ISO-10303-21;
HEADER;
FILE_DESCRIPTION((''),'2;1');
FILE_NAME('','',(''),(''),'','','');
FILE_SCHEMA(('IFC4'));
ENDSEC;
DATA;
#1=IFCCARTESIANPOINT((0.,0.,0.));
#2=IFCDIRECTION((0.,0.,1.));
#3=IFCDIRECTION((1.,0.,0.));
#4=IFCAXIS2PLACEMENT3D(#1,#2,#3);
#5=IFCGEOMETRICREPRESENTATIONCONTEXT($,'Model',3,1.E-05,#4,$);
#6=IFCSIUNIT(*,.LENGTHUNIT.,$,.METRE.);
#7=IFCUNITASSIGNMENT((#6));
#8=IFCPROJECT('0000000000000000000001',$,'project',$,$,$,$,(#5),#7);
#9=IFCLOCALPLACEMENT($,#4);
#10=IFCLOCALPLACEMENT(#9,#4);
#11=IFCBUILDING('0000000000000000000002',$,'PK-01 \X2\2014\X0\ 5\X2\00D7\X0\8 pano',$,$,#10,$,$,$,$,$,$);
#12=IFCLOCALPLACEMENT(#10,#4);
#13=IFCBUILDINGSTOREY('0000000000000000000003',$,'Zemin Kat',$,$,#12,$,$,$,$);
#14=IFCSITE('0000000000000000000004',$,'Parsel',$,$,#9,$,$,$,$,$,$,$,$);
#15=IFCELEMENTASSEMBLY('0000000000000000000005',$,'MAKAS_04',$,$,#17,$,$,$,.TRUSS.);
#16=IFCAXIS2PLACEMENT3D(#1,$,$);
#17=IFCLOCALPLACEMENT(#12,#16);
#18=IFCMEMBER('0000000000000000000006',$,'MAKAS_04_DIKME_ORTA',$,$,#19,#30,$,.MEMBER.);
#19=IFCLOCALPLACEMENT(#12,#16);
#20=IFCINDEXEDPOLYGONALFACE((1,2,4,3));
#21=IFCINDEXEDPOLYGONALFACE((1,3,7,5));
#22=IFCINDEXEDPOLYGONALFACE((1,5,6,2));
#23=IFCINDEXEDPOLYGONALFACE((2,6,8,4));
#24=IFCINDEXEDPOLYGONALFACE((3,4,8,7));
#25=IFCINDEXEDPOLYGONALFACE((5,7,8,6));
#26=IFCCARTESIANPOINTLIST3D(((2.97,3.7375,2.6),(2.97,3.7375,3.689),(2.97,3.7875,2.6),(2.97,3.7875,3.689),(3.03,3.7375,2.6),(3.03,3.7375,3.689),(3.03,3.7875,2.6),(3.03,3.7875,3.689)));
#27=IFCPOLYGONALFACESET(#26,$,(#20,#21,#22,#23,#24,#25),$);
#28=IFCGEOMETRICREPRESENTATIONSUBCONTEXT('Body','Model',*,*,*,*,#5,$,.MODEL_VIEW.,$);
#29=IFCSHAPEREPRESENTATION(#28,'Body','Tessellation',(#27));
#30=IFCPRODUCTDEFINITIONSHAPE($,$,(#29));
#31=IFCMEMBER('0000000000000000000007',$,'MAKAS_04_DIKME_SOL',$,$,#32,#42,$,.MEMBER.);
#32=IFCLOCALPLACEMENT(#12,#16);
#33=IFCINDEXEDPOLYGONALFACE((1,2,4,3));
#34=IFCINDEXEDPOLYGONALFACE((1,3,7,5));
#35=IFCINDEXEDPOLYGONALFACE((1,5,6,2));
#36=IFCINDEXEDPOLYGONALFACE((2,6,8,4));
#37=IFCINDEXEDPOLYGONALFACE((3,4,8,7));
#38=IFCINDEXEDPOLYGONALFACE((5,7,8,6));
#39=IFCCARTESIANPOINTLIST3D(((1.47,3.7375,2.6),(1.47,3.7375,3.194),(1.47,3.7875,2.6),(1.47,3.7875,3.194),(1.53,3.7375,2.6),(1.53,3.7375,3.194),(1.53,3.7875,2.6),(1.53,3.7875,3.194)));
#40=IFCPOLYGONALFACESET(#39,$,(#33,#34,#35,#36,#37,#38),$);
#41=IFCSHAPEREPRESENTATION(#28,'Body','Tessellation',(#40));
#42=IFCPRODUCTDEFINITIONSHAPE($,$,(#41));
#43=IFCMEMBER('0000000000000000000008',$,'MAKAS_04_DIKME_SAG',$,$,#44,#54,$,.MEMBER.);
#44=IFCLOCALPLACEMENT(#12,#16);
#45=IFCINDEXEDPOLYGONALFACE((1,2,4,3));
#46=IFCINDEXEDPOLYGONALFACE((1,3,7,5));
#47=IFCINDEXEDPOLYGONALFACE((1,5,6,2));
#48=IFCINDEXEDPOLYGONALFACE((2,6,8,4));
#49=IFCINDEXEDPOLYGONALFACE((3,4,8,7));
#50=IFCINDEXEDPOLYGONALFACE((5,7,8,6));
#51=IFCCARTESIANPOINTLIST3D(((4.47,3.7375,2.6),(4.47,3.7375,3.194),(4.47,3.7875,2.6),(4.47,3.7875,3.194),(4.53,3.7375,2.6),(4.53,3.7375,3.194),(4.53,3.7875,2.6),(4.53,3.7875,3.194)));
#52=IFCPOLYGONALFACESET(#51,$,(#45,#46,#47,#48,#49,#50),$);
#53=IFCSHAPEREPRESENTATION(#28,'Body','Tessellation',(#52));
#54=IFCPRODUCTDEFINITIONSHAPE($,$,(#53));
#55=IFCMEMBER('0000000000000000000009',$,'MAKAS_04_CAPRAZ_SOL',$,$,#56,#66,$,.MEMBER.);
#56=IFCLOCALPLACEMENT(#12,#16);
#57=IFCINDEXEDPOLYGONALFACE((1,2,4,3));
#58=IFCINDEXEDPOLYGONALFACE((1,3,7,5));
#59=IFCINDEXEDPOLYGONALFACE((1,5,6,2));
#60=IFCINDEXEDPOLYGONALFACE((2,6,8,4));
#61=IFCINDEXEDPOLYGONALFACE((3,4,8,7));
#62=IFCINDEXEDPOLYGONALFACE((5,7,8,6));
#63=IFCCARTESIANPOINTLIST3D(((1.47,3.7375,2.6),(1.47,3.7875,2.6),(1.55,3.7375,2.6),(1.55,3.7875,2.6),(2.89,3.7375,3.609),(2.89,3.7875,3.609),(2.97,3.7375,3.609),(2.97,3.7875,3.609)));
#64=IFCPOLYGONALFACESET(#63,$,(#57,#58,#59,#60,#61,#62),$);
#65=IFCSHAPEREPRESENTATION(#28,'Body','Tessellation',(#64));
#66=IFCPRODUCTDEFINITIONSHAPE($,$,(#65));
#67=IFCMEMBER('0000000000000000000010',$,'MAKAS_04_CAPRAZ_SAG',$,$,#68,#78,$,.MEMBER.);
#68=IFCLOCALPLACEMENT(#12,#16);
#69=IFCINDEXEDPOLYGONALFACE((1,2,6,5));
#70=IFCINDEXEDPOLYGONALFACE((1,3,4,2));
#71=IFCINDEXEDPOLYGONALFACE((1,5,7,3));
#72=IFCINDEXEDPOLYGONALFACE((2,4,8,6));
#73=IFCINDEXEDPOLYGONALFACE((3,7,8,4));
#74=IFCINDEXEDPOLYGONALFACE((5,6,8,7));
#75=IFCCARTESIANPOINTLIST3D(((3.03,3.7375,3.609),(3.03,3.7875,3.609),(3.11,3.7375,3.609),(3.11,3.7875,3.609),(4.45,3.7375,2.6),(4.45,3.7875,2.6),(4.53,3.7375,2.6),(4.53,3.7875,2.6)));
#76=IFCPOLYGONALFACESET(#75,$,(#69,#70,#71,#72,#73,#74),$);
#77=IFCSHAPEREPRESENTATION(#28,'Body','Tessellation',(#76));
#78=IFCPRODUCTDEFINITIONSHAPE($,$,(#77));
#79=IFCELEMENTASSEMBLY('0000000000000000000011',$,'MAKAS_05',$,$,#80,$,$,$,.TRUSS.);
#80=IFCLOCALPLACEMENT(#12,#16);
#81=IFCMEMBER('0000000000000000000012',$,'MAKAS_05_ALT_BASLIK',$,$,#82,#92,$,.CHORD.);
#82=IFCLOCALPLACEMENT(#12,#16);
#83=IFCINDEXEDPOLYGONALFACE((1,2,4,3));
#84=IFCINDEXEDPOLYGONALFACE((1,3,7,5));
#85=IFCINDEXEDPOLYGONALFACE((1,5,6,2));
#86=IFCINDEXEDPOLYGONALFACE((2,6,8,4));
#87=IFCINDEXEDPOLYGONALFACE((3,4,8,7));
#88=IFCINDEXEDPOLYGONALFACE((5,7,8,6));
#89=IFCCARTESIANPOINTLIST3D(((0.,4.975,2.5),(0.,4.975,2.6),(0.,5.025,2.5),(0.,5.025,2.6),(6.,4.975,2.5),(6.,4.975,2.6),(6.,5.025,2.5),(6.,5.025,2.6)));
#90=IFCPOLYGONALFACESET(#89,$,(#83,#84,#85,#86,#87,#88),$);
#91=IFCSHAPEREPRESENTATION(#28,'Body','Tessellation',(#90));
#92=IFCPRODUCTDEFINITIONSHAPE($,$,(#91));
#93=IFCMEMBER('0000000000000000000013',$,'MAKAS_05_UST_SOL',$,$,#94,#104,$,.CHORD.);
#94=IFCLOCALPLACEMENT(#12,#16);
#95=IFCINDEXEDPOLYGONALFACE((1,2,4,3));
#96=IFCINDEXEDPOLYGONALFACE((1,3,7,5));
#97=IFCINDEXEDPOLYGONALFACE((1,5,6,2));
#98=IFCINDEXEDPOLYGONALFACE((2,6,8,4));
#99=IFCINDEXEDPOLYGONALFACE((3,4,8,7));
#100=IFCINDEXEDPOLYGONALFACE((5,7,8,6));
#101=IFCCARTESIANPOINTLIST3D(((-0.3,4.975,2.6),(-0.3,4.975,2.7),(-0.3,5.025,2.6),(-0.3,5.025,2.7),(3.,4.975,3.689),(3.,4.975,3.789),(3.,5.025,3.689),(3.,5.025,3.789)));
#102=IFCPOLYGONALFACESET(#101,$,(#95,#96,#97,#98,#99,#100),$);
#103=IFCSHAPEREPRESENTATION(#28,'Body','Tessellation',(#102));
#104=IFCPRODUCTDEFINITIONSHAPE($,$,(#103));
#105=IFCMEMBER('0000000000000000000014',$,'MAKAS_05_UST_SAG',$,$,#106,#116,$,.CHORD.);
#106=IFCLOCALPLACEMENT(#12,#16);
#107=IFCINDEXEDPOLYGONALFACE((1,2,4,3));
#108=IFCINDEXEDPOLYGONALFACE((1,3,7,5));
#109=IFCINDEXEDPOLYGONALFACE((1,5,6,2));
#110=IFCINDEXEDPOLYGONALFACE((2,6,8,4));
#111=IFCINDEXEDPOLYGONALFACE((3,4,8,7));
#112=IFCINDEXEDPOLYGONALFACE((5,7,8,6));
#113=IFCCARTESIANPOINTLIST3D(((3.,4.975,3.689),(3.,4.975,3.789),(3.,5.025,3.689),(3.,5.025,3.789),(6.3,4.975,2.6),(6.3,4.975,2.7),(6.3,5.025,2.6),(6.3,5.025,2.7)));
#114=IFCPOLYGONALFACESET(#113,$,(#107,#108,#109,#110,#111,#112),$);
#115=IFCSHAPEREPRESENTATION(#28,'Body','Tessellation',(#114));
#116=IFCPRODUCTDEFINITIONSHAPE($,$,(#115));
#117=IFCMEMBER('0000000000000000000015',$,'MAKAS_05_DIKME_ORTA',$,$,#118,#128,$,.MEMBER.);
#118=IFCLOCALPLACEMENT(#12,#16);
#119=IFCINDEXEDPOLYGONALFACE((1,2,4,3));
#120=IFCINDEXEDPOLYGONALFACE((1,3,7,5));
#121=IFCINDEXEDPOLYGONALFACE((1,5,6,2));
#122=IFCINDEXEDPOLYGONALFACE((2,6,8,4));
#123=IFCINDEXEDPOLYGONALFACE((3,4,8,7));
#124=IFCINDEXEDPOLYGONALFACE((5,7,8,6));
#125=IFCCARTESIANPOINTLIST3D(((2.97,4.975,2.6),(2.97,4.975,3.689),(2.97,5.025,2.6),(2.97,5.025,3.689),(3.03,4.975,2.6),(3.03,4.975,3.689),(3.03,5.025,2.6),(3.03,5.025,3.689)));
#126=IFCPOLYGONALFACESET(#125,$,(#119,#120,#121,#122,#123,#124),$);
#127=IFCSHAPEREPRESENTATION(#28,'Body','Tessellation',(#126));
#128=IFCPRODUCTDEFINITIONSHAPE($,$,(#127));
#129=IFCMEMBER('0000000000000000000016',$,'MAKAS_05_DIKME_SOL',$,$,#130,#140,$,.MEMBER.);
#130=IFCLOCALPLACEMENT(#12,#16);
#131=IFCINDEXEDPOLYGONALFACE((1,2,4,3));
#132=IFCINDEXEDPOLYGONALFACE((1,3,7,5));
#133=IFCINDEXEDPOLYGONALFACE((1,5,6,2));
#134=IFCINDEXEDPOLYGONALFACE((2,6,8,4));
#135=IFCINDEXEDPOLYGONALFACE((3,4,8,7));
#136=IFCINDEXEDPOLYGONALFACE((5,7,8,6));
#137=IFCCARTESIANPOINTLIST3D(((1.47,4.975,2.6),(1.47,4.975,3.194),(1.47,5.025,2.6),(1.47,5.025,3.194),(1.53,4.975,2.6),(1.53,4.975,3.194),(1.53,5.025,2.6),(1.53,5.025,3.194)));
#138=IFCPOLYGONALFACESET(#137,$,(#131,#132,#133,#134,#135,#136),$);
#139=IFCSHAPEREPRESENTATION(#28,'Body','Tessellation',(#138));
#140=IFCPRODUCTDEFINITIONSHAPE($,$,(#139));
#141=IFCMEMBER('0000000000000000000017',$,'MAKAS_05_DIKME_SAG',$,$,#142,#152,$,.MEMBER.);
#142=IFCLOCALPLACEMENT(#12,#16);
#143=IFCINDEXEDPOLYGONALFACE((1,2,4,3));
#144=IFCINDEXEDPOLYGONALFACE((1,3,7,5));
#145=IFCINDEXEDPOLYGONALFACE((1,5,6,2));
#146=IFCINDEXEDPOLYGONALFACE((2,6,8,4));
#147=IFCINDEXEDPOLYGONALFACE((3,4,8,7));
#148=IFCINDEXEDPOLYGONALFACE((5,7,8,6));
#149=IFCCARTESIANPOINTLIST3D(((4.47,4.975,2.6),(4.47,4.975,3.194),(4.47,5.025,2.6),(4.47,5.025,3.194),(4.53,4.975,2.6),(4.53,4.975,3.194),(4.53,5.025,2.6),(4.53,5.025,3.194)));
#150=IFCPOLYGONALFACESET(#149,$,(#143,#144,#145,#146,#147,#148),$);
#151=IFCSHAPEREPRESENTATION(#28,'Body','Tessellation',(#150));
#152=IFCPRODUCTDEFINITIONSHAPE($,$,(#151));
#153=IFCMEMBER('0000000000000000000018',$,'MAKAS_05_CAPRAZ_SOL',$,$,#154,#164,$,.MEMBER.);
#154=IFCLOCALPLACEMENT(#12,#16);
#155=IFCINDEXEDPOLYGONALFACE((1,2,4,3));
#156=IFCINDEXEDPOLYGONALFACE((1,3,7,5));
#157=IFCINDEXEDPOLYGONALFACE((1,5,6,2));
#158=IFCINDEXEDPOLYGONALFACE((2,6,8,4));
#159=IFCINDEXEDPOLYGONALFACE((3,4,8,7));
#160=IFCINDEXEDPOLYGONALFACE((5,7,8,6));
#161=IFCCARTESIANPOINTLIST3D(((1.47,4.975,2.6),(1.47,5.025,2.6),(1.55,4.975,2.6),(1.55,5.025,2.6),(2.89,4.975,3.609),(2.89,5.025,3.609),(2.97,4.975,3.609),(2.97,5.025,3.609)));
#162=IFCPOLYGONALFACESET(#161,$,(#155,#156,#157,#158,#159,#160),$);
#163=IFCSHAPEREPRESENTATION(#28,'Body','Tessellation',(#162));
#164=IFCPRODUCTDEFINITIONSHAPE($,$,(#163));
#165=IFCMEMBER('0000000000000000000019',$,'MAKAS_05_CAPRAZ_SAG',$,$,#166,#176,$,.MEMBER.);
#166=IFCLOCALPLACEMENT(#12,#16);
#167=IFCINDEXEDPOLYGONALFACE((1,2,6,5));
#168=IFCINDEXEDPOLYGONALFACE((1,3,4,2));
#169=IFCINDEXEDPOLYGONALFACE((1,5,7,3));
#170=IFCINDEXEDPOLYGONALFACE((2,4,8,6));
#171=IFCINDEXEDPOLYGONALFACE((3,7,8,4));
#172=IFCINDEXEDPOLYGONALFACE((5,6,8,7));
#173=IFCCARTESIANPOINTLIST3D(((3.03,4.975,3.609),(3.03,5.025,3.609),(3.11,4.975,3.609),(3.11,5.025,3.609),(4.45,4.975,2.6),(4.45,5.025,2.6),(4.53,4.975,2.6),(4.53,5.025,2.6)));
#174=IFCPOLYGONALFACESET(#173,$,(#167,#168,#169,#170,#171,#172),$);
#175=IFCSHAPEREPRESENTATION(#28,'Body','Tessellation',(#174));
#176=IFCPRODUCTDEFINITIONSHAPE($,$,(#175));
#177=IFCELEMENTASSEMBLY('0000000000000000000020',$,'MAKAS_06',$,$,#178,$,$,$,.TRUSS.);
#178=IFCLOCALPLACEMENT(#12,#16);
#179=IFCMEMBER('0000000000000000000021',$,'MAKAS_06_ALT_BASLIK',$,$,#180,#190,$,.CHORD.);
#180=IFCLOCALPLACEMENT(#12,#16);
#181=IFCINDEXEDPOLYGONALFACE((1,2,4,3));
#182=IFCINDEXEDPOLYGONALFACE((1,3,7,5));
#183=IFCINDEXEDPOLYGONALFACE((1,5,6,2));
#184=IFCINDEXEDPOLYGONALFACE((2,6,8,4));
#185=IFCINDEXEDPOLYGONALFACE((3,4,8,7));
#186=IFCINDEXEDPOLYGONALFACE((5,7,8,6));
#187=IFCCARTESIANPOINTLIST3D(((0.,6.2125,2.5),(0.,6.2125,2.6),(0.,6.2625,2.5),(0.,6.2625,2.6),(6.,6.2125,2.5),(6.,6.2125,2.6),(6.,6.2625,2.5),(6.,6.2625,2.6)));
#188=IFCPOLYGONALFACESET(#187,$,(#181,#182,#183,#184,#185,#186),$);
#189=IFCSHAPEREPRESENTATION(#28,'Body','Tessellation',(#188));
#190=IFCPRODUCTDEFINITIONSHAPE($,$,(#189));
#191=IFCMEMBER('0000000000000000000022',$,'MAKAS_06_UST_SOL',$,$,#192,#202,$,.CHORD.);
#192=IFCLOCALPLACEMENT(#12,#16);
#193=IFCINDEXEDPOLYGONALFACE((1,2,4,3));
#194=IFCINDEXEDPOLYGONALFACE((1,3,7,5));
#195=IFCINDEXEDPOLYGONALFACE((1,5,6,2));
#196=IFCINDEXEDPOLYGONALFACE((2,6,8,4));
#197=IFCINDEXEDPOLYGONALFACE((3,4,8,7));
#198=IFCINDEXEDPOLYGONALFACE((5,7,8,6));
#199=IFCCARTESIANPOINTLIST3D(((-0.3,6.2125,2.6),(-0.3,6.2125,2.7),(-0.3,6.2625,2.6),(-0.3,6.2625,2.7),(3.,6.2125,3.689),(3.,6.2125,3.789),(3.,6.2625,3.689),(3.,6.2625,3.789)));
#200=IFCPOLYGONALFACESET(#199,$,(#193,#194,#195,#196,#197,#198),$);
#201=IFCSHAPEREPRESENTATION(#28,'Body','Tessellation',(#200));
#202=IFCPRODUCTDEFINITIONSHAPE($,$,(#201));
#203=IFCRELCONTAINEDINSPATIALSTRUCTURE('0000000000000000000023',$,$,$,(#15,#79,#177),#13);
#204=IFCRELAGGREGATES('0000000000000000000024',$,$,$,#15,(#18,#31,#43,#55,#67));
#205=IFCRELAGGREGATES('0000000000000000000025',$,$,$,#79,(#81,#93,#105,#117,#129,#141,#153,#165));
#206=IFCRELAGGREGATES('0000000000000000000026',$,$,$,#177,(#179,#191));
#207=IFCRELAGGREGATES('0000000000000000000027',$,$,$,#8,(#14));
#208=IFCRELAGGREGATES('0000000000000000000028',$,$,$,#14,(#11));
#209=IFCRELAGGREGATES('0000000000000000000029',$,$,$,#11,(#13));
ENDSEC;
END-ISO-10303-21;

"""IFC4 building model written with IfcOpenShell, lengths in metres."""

from ifc_helpers import new_model, si_unit, frame, origin_with_axes, place, context, subcontext, project, spatial, line, indexed_curve, outline, extrude, element, aggregate, save


model = new_model("IFC4")

# Units and contexts
model_context = context("Model", 3, precision=1e-05, world=origin_with_axes())
body_context = subcontext(model_context, "Body", "Model", "MODEL_VIEW")
ifc_project = project(units=[si_unit("LENGTHUNIT", "METRE")], contexts=[model_context])

# Site, building, storey
site_placement = place(None, origin_with_axes())
site = spatial("IfcSite", under=ifc_project, at=site_placement, Name="Parsel")
building_placement = place(site_placement, origin_with_axes())
building = spatial("IfcBuilding", under=site, at=building_placement, Name="PK-01 — 5×8 pano")
storey_placement = place(building_placement, origin_with_axes())
storey = spatial("IfcBuildingStorey", under=building, at=storey_placement, Name="Zemin Kat")

# Element assemblies, members
assembly_1_placement = place(storey_placement, origin_with_axes())
assembly_1 = element("IfcElementAssembly", 1, at=assembly_1_placement, inside=storey, Name="MAKAS_04", PredefinedType="TRUSS")
member_1_placement = place(assembly_1_placement, origin_with_axes())
member_1 = element("IfcMember", 2, at=member_1_placement, Name="MAKAS_04_DIKME_ORTA", PredefinedType="MEMBER", context=body_context, shape_type="SweptSolid", body=[
    extrude(outline(indexed_curve([(2.97, 2.6), (3.03, 2.6), (3.03, 3.689), (2.97, 3.689)], segments=[line(1, 2, 3, 4, 1)])), frame((0.0, 3.7875, 0.0), z_axis=(0.0, -1.0, 0.0), x_axis=(1.0, 0.0, 0.0)), (0.0, 0.0, 1.0), 0.05),
])
member_2_placement = place(assembly_1_placement, origin_with_axes())
member_2 = element("IfcMember", 3, at=member_2_placement, Name="MAKAS_04_DIKME_SOL", PredefinedType="MEMBER", context=body_context, shape_type="SweptSolid", body=[
    extrude(outline(indexed_curve([(1.47, 2.6), (1.53, 2.6), (1.53, 3.194), (1.47, 3.194)], segments=[line(1, 2, 3, 4, 1)])), frame((0.0, 3.7875, 0.0), z_axis=(0.0, -1.0, 0.0), x_axis=(1.0, 0.0, 0.0)), (0.0, 0.0, 1.0), 0.05),
])
member_3_placement = place(assembly_1_placement, origin_with_axes())
member_3 = element("IfcMember", 4, at=member_3_placement, Name="MAKAS_04_DIKME_SAG", PredefinedType="MEMBER", context=body_context, shape_type="SweptSolid", body=[
    extrude(outline(indexed_curve([(4.47, 2.6), (4.53, 2.6), (4.53, 3.194), (4.47, 3.194)], segments=[line(1, 2, 3, 4, 1)])), frame((0.0, 3.7875, 0.0), z_axis=(0.0, -1.0, 0.0), x_axis=(1.0, 0.0, 0.0)), (0.0, 0.0, 1.0), 0.05),
])
member_4_placement = place(assembly_1_placement, origin_with_axes())
member_4 = element("IfcMember", 5, at=member_4_placement, Name="MAKAS_04_CAPRAZ_SOL", PredefinedType="MEMBER", context=body_context, shape_type="SweptSolid", body=[
    extrude(outline(indexed_curve([(1.47, 2.6), (1.55, 2.6), (2.97, 3.609), (2.89, 3.609)], segments=[line(1, 2, 3, 4, 1)])), frame((0.0, 3.7875, 0.0), z_axis=(0.0, -1.0, 0.0), x_axis=(1.0, 0.0, 0.0)), (0.0, 0.0, 1.0), 0.05),
])
member_5_placement = place(assembly_1_placement, origin_with_axes())
member_5 = element("IfcMember", 6, at=member_5_placement, Name="MAKAS_04_CAPRAZ_SAG", PredefinedType="MEMBER", context=body_context, shape_type="SweptSolid", body=[
    extrude(outline(indexed_curve([(4.45, 2.6), (4.53, 2.6), (3.11, 3.609), (3.03, 3.609)], segments=[line(1, 2, 3, 4, 1)])), frame((0.0, 3.7875, 0.0), z_axis=(0.0, -1.0, 0.0), x_axis=(1.0, 0.0, 0.0)), (0.0, 0.0, 1.0), 0.05),
])
aggregate(assembly_1, [member_1, member_2, member_3, member_4, member_5])
assembly_2_placement = place(storey_placement, origin_with_axes())
assembly_2 = element("IfcElementAssembly", 7, at=assembly_2_placement, inside=storey, Name="MAKAS_05", PredefinedType="TRUSS")
member_6_placement = place(assembly_2_placement, origin_with_axes())
member_6 = element("IfcMember", 8, at=member_6_placement, Name="MAKAS_05_ALT_BASLIK", PredefinedType="CHORD", context=body_context, shape_type="SweptSolid", body=[
    extrude(outline(indexed_curve([(0.0, 2.5), (6.0, 2.5), (6.0, 2.6), (0.0, 2.6)], segments=[line(1, 2, 3, 4, 1)])), frame((0.0, 5.025, 0.0), z_axis=(0.0, -1.0, 0.0), x_axis=(1.0, 0.0, 0.0)), (0.0, 0.0, 1.0), 0.05),
])
member_7_placement = place(assembly_2_placement, origin_with_axes())
member_7 = element("IfcMember", 9, at=member_7_placement, Name="MAKAS_05_UST_SOL", PredefinedType="CHORD", context=body_context, shape_type="SweptSolid", body=[
    extrude(outline(indexed_curve([(-0.3, 2.6), (3.0, 3.689), (3.0, 3.789), (-0.3, 2.7)], segments=[line(1, 2, 3, 4, 1)])), frame((0.0, 5.025, 0.0), z_axis=(0.0, -1.0, 0.0), x_axis=(1.0, 0.0, 0.0)), (0.0, 0.0, 1.0), 0.05),
])
member_8_placement = place(assembly_2_placement, origin_with_axes())
member_8 = element("IfcMember", 10, at=member_8_placement, Name="MAKAS_05_UST_SAG", PredefinedType="CHORD", context=body_context, shape_type="SweptSolid", body=[
    extrude(outline(indexed_curve([(3.0, 3.689), (6.3, 2.6), (6.3, 2.7), (3.0, 3.789)], segments=[line(1, 2, 3, 4, 1)])), frame((0.0, 5.025, 0.0), z_axis=(0.0, -1.0, 0.0), x_axis=(1.0, 0.0, 0.0)), (0.0, 0.0, 1.0), 0.05),
])
member_9_placement = place(assembly_2_placement, origin_with_axes())
member_9 = element("IfcMember", 11, at=member_9_placement, Name="MAKAS_05_DIKME_ORTA", PredefinedType="MEMBER", context=body_context, shape_type="SweptSolid", body=[
    extrude(outline(indexed_curve([(2.97, 2.6), (3.03, 2.6), (3.03, 3.689), (2.97, 3.689)], segments=[line(1, 2, 3, 4, 1)])), frame((0.0, 5.025, 0.0), z_axis=(0.0, -1.0, 0.0), x_axis=(1.0, 0.0, 0.0)), (0.0, 0.0, 1.0), 0.05),
])
member_10_placement = place(assembly_2_placement, origin_with_axes())
member_10 = element("IfcMember", 12, at=member_10_placement, Name="MAKAS_05_DIKME_SOL", PredefinedType="MEMBER", context=body_context, shape_type="SweptSolid", body=[
    extrude(outline(indexed_curve([(1.47, 2.6), (1.53, 2.6), (1.53, 3.194), (1.47, 3.194)], segments=[line(1, 2, 3, 4, 1)])), frame((0.0, 5.025, 0.0), z_axis=(0.0, -1.0, 0.0), x_axis=(1.0, 0.0, 0.0)), (0.0, 0.0, 1.0), 0.05),
])
member_11_placement = place(assembly_2_placement, origin_with_axes())
member_11 = element("IfcMember", 13, at=member_11_placement, Name="MAKAS_05_DIKME_SAG", PredefinedType="MEMBER", context=body_context, shape_type="SweptSolid", body=[
    extrude(outline(indexed_curve([(4.47, 2.6), (4.53, 2.6), (4.53, 3.194), (4.47, 3.194)], segments=[line(1, 2, 3, 4, 1)])), frame((0.0, 5.025, 0.0), z_axis=(0.0, -1.0, 0.0), x_axis=(1.0, 0.0, 0.0)), (0.0, 0.0, 1.0), 0.05),
])
member_12_placement = place(assembly_2_placement, origin_with_axes())
member_12 = element("IfcMember", 14, at=member_12_placement, Name="MAKAS_05_CAPRAZ_SOL", PredefinedType="MEMBER", context=body_context, shape_type="SweptSolid", body=[
    extrude(outline(indexed_curve([(1.47, 2.6), (1.55, 2.6), (2.97, 3.609), (2.89, 3.609)], segments=[line(1, 2, 3, 4, 1)])), frame((0.0, 5.025, 0.0), z_axis=(0.0, -1.0, 0.0), x_axis=(1.0, 0.0, 0.0)), (0.0, 0.0, 1.0), 0.05),
])
member_13_placement = place(assembly_2_placement, origin_with_axes())
member_13 = element("IfcMember", 15, at=member_13_placement, Name="MAKAS_05_CAPRAZ_SAG", PredefinedType="MEMBER", context=body_context, shape_type="SweptSolid", body=[
    extrude(outline(indexed_curve([(4.45, 2.6), (4.53, 2.6), (3.11, 3.609), (3.03, 3.609)], segments=[line(1, 2, 3, 4, 1)])), frame((0.0, 5.025, 0.0), z_axis=(0.0, -1.0, 0.0), x_axis=(1.0, 0.0, 0.0)), (0.0, 0.0, 1.0), 0.05),
])
aggregate(assembly_2, [member_6, member_7, member_8, member_9, member_10, member_11, member_12, member_13])
assembly_3_placement = place(storey_placement, origin_with_axes())
assembly_3 = element("IfcElementAssembly", 16, at=assembly_3_placement, inside=storey, Name="MAKAS_06", PredefinedType="TRUSS")
member_14_placement = place(assembly_3_placement, origin_with_axes())
member_14 = element("IfcMember", 17, at=member_14_placement, Name="MAKAS_06_ALT_BASLIK", PredefinedType="CHORD", context=body_context, shape_type="SweptSolid", body=[
    extrude(outline(indexed_curve([(0.0, 2.5), (6.0, 2.5), (6.0, 2.6), (0.0, 2.6)], segments=[line(1, 2, 3, 4, 1)])), frame((0.0, 6.2625, 0.0), z_axis=(0.0, -1.0, 0.0), x_axis=(1.0, 0.0, 0.0)), (0.0, 0.0, 1.0), 0.05),
])
member_15_placement = place(assembly_3_placement, origin_with_axes())
member_15 = element("IfcMember", 18, at=member_15_placement, Name="MAKAS_06_UST_SOL", PredefinedType="CHORD", context=body_context, shape_type="SweptSolid", body=[
    extrude(outline(indexed_curve([(-0.3, 2.6), (3.0, 3.689), (3.0, 3.789), (-0.3, 2.7)], segments=[line(1, 2, 3, 4, 1)])), frame((0.0, 6.2625, 0.0), z_axis=(0.0, -1.0, 0.0), x_axis=(1.0, 0.0, 0.0)), (0.0, 0.0, 1.0), 0.05),
])
aggregate(assembly_3, [member_14, member_15])

save(model, "model.ifc")
